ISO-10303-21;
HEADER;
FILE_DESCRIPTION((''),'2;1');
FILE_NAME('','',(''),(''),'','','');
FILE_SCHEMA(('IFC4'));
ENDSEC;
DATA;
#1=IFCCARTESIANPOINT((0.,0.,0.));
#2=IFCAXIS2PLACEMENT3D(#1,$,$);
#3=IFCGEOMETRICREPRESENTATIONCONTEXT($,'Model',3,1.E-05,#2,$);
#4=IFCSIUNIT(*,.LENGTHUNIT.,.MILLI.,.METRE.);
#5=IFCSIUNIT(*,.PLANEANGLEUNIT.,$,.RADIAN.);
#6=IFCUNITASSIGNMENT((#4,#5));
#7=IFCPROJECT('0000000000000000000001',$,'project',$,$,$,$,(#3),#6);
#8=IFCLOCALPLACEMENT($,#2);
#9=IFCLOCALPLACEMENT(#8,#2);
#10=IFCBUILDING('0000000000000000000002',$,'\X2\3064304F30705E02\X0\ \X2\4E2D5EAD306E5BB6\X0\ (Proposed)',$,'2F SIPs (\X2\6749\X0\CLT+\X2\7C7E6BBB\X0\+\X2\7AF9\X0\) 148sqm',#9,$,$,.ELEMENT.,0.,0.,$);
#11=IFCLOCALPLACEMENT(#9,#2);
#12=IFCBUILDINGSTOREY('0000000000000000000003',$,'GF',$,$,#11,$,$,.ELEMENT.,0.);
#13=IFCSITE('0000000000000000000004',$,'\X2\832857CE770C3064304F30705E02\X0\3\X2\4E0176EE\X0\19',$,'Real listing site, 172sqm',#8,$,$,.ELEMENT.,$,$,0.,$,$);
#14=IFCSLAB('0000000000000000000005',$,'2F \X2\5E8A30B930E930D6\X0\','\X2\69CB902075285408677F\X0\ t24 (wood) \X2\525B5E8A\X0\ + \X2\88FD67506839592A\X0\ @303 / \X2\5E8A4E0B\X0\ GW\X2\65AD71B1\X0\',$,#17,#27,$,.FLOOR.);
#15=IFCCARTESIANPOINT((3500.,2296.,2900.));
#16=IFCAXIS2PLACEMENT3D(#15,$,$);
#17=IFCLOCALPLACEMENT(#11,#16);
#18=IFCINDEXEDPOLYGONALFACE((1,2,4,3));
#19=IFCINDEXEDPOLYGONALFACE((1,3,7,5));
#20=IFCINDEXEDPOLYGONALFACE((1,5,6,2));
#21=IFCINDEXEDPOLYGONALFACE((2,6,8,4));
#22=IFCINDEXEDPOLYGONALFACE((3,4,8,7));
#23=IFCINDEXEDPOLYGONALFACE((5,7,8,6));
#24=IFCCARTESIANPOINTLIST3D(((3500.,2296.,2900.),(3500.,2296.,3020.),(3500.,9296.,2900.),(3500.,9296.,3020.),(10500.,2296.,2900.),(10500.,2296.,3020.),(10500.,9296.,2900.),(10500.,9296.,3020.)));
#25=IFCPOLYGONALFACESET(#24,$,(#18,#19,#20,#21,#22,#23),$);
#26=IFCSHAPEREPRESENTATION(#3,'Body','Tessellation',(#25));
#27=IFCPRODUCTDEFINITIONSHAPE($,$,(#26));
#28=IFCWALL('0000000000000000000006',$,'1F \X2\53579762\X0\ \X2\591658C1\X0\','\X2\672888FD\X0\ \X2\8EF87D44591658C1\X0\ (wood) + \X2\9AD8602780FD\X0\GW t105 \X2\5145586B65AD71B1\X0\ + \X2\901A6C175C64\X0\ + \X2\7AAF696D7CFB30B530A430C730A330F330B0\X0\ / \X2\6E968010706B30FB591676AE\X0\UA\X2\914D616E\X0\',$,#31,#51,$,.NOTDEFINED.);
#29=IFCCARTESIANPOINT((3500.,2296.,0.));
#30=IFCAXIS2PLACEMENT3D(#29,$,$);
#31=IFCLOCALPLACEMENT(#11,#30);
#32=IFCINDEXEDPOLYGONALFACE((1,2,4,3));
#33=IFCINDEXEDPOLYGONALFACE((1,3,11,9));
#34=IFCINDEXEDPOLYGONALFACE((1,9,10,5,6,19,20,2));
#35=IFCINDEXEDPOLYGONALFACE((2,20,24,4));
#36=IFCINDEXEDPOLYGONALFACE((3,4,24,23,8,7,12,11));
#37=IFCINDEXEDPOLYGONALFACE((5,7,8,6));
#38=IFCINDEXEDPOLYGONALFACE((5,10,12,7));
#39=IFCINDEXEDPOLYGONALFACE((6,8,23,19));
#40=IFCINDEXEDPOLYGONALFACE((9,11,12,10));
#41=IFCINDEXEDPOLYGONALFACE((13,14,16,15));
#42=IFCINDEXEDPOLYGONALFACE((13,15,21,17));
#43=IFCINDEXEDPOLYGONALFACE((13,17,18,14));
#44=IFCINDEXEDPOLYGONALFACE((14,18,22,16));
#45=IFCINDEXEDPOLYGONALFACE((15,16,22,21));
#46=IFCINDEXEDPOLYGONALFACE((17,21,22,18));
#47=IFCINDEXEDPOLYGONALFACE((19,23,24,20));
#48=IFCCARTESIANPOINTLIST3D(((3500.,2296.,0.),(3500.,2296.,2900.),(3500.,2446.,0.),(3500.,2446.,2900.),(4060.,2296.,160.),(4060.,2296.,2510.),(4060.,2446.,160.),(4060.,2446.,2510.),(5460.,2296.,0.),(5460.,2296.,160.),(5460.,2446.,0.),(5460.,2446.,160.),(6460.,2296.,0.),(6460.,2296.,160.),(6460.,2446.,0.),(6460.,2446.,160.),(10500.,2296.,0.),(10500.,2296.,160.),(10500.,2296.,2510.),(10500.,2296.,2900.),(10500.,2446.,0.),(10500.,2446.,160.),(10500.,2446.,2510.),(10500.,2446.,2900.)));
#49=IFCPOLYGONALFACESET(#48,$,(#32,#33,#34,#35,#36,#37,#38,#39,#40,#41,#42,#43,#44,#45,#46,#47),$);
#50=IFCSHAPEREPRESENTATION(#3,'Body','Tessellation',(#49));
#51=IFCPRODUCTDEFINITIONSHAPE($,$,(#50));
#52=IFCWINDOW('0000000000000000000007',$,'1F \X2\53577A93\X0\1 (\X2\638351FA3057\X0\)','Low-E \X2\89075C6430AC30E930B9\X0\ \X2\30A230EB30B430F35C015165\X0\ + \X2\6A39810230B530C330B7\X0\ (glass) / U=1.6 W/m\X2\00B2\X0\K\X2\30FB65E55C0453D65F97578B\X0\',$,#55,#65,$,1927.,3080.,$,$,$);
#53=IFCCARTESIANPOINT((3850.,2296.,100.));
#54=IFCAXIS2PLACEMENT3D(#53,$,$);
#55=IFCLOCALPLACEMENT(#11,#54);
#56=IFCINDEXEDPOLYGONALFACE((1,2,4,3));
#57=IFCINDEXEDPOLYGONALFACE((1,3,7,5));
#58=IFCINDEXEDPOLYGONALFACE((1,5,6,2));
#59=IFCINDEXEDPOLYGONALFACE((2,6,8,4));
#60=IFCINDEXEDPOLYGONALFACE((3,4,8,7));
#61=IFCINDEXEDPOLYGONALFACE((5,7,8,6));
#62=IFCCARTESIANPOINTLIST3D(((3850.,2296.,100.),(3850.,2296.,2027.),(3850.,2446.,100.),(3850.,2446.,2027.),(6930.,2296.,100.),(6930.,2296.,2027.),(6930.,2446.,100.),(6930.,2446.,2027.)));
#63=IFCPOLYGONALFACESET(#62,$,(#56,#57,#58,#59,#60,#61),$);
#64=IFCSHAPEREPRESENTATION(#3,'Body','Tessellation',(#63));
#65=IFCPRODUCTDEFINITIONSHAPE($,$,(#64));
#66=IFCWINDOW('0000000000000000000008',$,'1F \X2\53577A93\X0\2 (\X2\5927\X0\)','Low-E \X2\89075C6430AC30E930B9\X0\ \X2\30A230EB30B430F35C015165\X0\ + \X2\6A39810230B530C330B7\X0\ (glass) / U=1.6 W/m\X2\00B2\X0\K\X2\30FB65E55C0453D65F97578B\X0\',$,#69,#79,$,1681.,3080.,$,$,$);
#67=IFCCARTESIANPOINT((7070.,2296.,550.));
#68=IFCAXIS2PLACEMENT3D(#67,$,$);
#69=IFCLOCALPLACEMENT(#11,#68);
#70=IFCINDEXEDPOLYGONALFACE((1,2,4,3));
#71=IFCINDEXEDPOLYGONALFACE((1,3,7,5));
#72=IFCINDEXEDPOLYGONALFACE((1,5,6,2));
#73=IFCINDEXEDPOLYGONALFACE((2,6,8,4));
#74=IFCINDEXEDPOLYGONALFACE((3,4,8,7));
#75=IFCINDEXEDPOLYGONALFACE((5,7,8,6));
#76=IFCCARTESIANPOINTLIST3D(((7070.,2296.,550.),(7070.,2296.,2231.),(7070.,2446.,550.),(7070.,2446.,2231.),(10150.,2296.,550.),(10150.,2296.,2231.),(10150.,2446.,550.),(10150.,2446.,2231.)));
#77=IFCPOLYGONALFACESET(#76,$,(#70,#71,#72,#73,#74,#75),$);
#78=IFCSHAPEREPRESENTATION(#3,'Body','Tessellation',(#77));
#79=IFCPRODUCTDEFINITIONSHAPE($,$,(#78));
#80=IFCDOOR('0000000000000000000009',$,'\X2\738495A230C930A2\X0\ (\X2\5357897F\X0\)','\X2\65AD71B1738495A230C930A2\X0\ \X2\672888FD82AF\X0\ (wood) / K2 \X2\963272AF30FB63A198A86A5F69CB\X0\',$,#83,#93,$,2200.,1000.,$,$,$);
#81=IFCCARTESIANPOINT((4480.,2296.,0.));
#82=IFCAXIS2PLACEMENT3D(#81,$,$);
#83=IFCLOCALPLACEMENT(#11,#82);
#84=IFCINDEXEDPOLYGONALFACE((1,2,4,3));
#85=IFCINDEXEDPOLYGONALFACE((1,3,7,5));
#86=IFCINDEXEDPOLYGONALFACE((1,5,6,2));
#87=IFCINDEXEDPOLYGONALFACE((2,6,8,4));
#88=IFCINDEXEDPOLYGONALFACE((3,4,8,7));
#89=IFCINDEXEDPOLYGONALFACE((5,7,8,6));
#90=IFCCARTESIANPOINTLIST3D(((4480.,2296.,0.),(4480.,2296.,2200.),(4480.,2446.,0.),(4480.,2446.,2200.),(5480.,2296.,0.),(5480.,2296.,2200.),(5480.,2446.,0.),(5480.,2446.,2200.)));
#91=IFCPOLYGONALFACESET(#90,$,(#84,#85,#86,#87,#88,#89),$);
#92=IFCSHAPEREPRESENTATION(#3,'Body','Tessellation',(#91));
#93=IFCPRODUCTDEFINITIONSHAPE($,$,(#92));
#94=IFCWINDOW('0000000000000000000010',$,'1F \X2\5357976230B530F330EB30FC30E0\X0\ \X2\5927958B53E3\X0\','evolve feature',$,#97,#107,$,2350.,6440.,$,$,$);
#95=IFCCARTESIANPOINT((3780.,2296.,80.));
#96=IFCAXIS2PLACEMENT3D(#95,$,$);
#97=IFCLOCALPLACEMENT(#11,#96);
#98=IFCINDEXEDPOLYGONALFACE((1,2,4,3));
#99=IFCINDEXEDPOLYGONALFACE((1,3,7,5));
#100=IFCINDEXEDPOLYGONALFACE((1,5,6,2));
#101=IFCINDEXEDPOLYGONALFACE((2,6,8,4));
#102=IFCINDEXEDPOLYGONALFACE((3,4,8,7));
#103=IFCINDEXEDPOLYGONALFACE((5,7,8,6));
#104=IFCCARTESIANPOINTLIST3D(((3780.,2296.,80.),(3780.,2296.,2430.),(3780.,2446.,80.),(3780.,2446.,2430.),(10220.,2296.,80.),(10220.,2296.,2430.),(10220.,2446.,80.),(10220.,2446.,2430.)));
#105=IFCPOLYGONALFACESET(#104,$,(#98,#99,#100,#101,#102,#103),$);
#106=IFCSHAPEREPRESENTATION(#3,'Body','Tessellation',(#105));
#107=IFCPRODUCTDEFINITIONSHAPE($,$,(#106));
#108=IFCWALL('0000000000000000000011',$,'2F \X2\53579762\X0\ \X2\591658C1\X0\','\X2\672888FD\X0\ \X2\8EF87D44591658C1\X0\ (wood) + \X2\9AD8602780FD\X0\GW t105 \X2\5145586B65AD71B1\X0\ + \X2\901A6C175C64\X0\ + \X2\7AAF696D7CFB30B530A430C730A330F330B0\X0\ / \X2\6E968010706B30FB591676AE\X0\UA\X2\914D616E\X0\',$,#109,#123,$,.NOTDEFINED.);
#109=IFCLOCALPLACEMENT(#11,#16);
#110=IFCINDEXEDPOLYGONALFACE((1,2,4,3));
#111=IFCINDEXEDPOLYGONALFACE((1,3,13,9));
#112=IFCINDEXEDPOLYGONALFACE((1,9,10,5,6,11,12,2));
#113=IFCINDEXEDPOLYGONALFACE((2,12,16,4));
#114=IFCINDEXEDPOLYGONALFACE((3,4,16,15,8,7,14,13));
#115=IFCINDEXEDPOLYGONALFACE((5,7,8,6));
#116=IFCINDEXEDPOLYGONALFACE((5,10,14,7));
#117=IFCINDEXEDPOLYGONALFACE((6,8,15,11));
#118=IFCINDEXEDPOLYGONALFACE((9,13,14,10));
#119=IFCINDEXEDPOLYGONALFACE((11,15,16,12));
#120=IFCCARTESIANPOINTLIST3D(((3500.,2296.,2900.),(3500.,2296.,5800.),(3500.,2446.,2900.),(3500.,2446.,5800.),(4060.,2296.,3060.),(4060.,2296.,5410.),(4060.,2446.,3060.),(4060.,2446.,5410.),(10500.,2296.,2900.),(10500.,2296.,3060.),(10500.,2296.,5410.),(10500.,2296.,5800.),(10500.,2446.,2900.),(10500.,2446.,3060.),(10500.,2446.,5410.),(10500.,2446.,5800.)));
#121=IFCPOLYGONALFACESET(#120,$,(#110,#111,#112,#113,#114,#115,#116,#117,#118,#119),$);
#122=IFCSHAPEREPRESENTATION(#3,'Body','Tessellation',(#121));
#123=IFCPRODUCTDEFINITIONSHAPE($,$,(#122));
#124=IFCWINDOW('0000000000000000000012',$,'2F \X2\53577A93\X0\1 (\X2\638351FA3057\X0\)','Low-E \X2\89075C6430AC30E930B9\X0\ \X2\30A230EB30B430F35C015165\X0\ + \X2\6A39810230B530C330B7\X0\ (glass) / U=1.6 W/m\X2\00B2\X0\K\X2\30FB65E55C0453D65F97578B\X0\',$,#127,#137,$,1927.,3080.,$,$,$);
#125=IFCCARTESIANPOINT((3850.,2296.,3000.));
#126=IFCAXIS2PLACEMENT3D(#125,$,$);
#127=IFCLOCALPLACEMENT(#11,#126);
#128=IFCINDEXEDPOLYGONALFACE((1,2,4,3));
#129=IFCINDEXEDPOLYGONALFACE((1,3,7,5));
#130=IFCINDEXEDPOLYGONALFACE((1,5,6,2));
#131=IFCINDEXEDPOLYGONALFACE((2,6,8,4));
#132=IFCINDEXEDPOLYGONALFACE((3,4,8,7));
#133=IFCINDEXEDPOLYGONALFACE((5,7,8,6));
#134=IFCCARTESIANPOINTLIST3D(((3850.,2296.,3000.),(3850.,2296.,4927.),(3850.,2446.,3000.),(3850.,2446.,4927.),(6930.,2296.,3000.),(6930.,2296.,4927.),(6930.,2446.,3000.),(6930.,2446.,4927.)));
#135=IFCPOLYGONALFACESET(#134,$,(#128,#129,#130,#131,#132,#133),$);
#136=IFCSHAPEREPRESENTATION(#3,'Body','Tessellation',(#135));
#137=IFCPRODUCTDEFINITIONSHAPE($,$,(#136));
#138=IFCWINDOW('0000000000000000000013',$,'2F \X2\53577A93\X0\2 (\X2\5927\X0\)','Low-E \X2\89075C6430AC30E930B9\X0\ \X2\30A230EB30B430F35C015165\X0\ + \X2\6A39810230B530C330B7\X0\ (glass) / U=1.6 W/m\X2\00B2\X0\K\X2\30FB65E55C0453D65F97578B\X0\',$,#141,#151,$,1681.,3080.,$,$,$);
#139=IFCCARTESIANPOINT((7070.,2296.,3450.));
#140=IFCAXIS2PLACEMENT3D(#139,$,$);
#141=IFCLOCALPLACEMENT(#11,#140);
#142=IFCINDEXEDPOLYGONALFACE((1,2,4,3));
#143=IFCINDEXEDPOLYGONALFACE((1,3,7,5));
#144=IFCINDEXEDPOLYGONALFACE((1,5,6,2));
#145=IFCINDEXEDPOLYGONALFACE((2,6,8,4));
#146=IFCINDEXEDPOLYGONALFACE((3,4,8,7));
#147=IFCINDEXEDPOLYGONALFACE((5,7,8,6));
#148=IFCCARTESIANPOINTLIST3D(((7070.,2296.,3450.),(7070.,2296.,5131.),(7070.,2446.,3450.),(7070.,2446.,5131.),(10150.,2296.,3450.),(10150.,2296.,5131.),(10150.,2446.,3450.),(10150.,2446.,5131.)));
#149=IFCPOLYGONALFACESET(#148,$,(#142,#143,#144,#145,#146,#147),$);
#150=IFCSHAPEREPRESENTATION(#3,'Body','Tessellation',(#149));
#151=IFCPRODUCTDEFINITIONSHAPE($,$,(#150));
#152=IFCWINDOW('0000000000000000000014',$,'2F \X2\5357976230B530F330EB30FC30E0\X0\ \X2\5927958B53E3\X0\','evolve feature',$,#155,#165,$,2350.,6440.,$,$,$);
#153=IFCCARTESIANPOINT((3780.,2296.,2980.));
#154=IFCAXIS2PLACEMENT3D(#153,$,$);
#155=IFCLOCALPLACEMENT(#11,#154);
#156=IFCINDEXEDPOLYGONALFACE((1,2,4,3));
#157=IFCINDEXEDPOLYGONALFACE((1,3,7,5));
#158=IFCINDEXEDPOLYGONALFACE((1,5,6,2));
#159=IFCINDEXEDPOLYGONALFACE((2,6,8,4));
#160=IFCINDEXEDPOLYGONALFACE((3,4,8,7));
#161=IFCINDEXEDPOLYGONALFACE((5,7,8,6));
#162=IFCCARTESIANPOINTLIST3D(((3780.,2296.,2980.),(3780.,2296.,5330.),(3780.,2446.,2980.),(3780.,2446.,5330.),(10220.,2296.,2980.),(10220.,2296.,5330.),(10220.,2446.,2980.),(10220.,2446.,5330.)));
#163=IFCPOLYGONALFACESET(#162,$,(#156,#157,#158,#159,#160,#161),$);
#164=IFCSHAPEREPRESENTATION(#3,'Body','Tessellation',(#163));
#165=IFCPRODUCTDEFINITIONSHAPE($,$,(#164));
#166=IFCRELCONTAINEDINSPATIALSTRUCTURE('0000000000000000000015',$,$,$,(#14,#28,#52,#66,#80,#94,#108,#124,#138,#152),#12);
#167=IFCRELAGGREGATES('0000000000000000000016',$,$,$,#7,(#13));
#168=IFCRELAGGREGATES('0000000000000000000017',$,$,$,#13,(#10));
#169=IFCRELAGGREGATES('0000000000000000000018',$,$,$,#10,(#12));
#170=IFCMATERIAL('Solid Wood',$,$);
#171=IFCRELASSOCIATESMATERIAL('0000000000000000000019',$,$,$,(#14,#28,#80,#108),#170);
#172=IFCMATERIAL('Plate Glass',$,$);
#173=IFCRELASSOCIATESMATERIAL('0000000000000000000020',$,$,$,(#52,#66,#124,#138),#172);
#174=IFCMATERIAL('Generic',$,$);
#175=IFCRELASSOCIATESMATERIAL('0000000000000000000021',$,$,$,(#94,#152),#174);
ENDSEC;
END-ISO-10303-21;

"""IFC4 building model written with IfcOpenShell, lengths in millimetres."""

from ifc_helpers import new_model, si_unit, frame, frame_2d, origin, place, context, project, spatial, rectangle, extrude, material, element, fill, save


model = new_model("IFC4")

# Units and contexts
model_context = context("Model", 3, precision=1e-05, world=origin())
ifc_project = project(units=[si_unit("LENGTHUNIT", "METRE", prefix="MILLI"), si_unit("PLANEANGLEUNIT", "RADIAN")], contexts=[model_context])

# Site, building, storey
site_placement = place(None, origin())
site = spatial("IfcSite", under=ifc_project, at=site_placement, Name="茨城県つくば市3丁目19", ObjectType="Real listing site, 172sqm", CompositionType="ELEMENT", RefElevation=0.0)
building_placement = place(site_placement, origin())
building = spatial("IfcBuilding", under=site, at=building_placement, Name="つくば市 中庭の家 (Proposed)", ObjectType="2F SIPs (杉CLT+籾殻+竹) 148sqm", CompositionType="ELEMENT", ElevationOfRefHeight=0.0, ElevationOfTerrain=0.0)
storey_placement = place(building_placement, origin())
storey = spatial("IfcBuildingStorey", under=building, at=storey_placement, Name="GF", CompositionType="ELEMENT", Elevation=0.0)

# Slab
ifc_material_1 = material(Name="Solid Wood")
slab_1_placement = place(storey_placement, frame((3500.0, 2296.0, 2900.0)))
element("IfcSlab", 1, at=slab_1_placement, inside=storey, material=ifc_material_1, Name="2F 床スラブ", Description="構造用合板 t24 (wood) 剛床 + 製材根太 @303 / 床下 GW断熱", PredefinedType="FLOOR", context=model_context, shape_type="SweptSolid", body=[
    extrude(rectangle(XDim=7000.0, YDim=7000.0, at=frame_2d((3500.0, 3500.0))), frame((3500.0, 2296.0, 2900.0)), (0.0, 0.0, 1.0), 120.0),
])
ifc_material_2 = material(Name="Generic")

# Wall, openings, windows, door
wall_1_placement = place(storey_placement, frame((3500.0, 2296.0, 0.0)))
wall_1 = element("IfcWall", 2, at=wall_1_placement, inside=storey, material=ifc_material_1, Name="1F 南面 外壁", Description="木製 軸組外壁 (wood) + 高性能GW t105 充填断熱 + 通気層 + 窯業系サイディング / 準耐火・外皮UA配慮", PredefinedType="NOTDEFINED", context=model_context, shape_type="SweptSolid", body=[
    extrude(rectangle(XDim=7000.0, YDim=150.0, at=frame_2d((3500.0, 75.0))), frame((3500.0, 2296.0, 0.0)), (0.0, 0.0, 1.0), 2900.0),
])
opening_1_placement = place(storey_placement, frame((3850.0, 2296.0, 100.0)))
opening_1 = element("IfcOpeningElement", 3, at=opening_1_placement, cuts=wall_1, PredefinedType="NOTDEFINED", context=model_context, shape_type="SweptSolid", body=[
    extrude(rectangle(XDim=3080.0, YDim=150.0, at=frame_2d((1540.0, 75.0))), frame((3850.0, 2296.0, 100.0)), (0.0, 0.0, 1.0), 1927.0),
])
opening_2_placement = place(storey_placement, frame((7070.0, 2296.0, 550.0)))
opening_2 = element("IfcOpeningElement", 4, at=opening_2_placement, cuts=wall_1, PredefinedType="NOTDEFINED", context=model_context, shape_type="SweptSolid", body=[
    extrude(rectangle(XDim=3080.0, YDim=150.0, at=frame_2d((1540.0, 75.0))), frame((7070.0, 2296.0, 550.0)), (0.0, 0.0, 1.0), 1681.0),
])
opening_3_placement = place(storey_placement, frame((4480.0, 2296.0, 0.0)))
opening_3 = element("IfcOpeningElement", 5, at=opening_3_placement, cuts=wall_1, PredefinedType="NOTDEFINED", context=model_context, shape_type="SweptSolid", body=[
    extrude(rectangle(XDim=1000.0, YDim=150.0, at=frame_2d((500.0, 75.0))), frame((4480.0, 2296.0, 0.0)), (0.0, 0.0, 1.0), 2200.0),
])
opening_4_placement = place(storey_placement, frame((3780.0, 2296.0, 80.0)))
opening_4 = element("IfcOpeningElement", 6, at=opening_4_placement, cuts=wall_1, PredefinedType="NOTDEFINED", context=model_context, shape_type="SweptSolid", body=[
    extrude(rectangle(XDim=6440.0, YDim=150.0, at=frame_2d((3220.0, 75.0))), frame((3780.0, 2296.0, 80.0)), (0.0, 0.0, 1.0), 2350.0),
])
ifc_material_3 = material(Name="Plate Glass")
window_1_placement = place(storey_placement, frame((3850.0, 2296.0, 100.0)))
window_1 = element("IfcWindow", 7, at=window_1_placement, inside=storey, material=ifc_material_3, Name="1F 南窓1 (掃出し)", Description="Low-E 複層ガラス アルゴン封入 + 樹脂サッシ (glass) / U=1.6 W/m²K・日射取得型", OverallHeight=1927.0, OverallWidth=3080.0, context=model_context, shape_type="SweptSolid", body=[
    extrude(rectangle(XDim=3080.0, YDim=150.0, at=frame_2d((1540.0, 75.0))), frame((3850.0, 2296.0, 100.0)), (0.0, 0.0, 1.0), 1927.0),
])
fill(opening_1, window_1)
window_2_placement = place(storey_placement, frame((7070.0, 2296.0, 550.0)))
window_2 = element("IfcWindow", 8, at=window_2_placement, inside=storey, material=ifc_material_3, Name="1F 南窓2 (大)", Description="Low-E 複層ガラス アルゴン封入 + 樹脂サッシ (glass) / U=1.6 W/m²K・日射取得型", OverallHeight=1681.0, OverallWidth=3080.0, context=model_context, shape_type="SweptSolid", body=[
    extrude(rectangle(XDim=3080.0, YDim=150.0, at=frame_2d((1540.0, 75.0))), frame((7070.0, 2296.0, 550.0)), (0.0, 0.0, 1.0), 1681.0),
])
fill(opening_2, window_2)
door_placement = place(storey_placement, frame((4480.0, 2296.0, 0.0)))
door = element("IfcDoor", 9, at=door_placement, inside=storey, material=ifc_material_1, Name="玄関ドア (南西)", Description="断熱玄関ドア 木製芯 (wood) / K2 防犯・採風機構", OverallHeight=2200.0, OverallWidth=1000.0, context=model_context, shape_type="SweptSolid", body=[
    extrude(rectangle(XDim=1000.0, YDim=150.0, at=frame_2d((500.0, 75.0))), frame((4480.0, 2296.0, 0.0)), (0.0, 0.0, 1.0), 2200.0),
])
fill(opening_3, door)
window_3_placement = place(storey_placement, frame((3780.0, 2296.0, 80.0)))
window_3 = element("IfcWindow", 10, at=window_3_placement, inside=storey, material=ifc_material_2, Name="1F 南面サンルーム 大開口", Description="evolve feature", OverallHeight=2350.0, OverallWidth=6440.0, context=model_context, shape_type="SweptSolid", body=[
    extrude(rectangle(XDim=6440.0, YDim=150.0, at=frame_2d((3220.0, 75.0))), frame((3780.0, 2296.0, 80.0)), (0.0, 0.0, 1.0), 2350.0),
])
fill(opening_4, window_3)

# Wall, openings, windows
wall_2_placement = place(storey_placement, frame((3500.0, 2296.0, 2900.0)))
wall_2 = element("IfcWall", 11, at=wall_2_placement, inside=storey, material=ifc_material_1, Name="2F 南面 外壁", Description="木製 軸組外壁 (wood) + 高性能GW t105 充填断熱 + 通気層 + 窯業系サイディング / 準耐火・外皮UA配慮", PredefinedType="NOTDEFINED", context=model_context, shape_type="SweptSolid", body=[
    extrude(rectangle(XDim=7000.0, YDim=150.0, at=frame_2d((3500.0, 75.0))), frame((3500.0, 2296.0, 2900.0)), (0.0, 0.0, 1.0), 2900.0),
])
opening_5_placement = place(storey_placement, frame((3850.0, 2296.0, 3000.0)))
opening_5 = element("IfcOpeningElement", 12, at=opening_5_placement, cuts=wall_2, PredefinedType="NOTDEFINED", context=model_context, shape_type="SweptSolid", body=[
    extrude(rectangle(XDim=3080.0, YDim=150.0, at=frame_2d((1540.0, 75.0))), frame((3850.0, 2296.0, 3000.0)), (0.0, 0.0, 1.0), 1927.0),
])
opening_6_placement = place(storey_placement, frame((7070.0, 2296.0, 3450.0)))
opening_6 = element("IfcOpeningElement", 13, at=opening_6_placement, cuts=wall_2, PredefinedType="NOTDEFINED", context=model_context, shape_type="SweptSolid", body=[
    extrude(rectangle(XDim=3080.0, YDim=150.0, at=frame_2d((1540.0, 75.0))), frame((7070.0, 2296.0, 3450.0)), (0.0, 0.0, 1.0), 1681.0),
])
opening_7_placement = place(storey_placement, frame((3780.0, 2296.0, 2980.0)))
opening_7 = element("IfcOpeningElement", 14, at=opening_7_placement, cuts=wall_2, PredefinedType="NOTDEFINED", context=model_context, shape_type="SweptSolid", body=[
    extrude(rectangle(XDim=6440.0, YDim=150.0, at=frame_2d((3220.0, 75.0))), frame((3780.0, 2296.0, 2980.0)), (0.0, 0.0, 1.0), 2350.0),
])
window_4_placement = place(storey_placement, frame((3850.0, 2296.0, 3000.0)))
window_4 = element("IfcWindow", 15, at=window_4_placement, inside=storey, material=ifc_material_3, Name="2F 南窓1 (掃出し)", Description="Low-E 複層ガラス アルゴン封入 + 樹脂サッシ (glass) / U=1.6 W/m²K・日射取得型", OverallHeight=1927.0, OverallWidth=3080.0, context=model_context, shape_type="SweptSolid", body=[
    extrude(rectangle(XDim=3080.0, YDim=150.0, at=frame_2d((1540.0, 75.0))), frame((3850.0, 2296.0, 3000.0)), (0.0, 0.0, 1.0), 1927.0),
])
fill(opening_5, window_4)
window_5_placement = place(storey_placement, frame((7070.0, 2296.0, 3450.0)))
window_5 = element("IfcWindow", 16, at=window_5_placement, inside=storey, material=ifc_material_3, Name="2F 南窓2 (大)", Description="Low-E 複層ガラス アルゴン封入 + 樹脂サッシ (glass) / U=1.6 W/m²K・日射取得型", OverallHeight=1681.0, OverallWidth=3080.0, context=model_context, shape_type="SweptSolid", body=[
    extrude(rectangle(XDim=3080.0, YDim=150.0, at=frame_2d((1540.0, 75.0))), frame((7070.0, 2296.0, 3450.0)), (0.0, 0.0, 1.0), 1681.0),
])
fill(opening_6, window_5)
window_6_placement = place(storey_placement, frame((3780.0, 2296.0, 2980.0)))
window_6 = element("IfcWindow", 17, at=window_6_placement, inside=storey, material=ifc_material_2, Name="2F 南面サンルーム 大開口", Description="evolve feature", OverallHeight=2350.0, OverallWidth=6440.0, context=model_context, shape_type="SweptSolid", body=[
    extrude(rectangle(XDim=6440.0, YDim=150.0, at=frame_2d((3220.0, 75.0))), frame((3780.0, 2296.0, 2980.0)), (0.0, 0.0, 1.0), 2350.0),
])
fill(opening_7, window_6)

save(model, "model.ifc")
